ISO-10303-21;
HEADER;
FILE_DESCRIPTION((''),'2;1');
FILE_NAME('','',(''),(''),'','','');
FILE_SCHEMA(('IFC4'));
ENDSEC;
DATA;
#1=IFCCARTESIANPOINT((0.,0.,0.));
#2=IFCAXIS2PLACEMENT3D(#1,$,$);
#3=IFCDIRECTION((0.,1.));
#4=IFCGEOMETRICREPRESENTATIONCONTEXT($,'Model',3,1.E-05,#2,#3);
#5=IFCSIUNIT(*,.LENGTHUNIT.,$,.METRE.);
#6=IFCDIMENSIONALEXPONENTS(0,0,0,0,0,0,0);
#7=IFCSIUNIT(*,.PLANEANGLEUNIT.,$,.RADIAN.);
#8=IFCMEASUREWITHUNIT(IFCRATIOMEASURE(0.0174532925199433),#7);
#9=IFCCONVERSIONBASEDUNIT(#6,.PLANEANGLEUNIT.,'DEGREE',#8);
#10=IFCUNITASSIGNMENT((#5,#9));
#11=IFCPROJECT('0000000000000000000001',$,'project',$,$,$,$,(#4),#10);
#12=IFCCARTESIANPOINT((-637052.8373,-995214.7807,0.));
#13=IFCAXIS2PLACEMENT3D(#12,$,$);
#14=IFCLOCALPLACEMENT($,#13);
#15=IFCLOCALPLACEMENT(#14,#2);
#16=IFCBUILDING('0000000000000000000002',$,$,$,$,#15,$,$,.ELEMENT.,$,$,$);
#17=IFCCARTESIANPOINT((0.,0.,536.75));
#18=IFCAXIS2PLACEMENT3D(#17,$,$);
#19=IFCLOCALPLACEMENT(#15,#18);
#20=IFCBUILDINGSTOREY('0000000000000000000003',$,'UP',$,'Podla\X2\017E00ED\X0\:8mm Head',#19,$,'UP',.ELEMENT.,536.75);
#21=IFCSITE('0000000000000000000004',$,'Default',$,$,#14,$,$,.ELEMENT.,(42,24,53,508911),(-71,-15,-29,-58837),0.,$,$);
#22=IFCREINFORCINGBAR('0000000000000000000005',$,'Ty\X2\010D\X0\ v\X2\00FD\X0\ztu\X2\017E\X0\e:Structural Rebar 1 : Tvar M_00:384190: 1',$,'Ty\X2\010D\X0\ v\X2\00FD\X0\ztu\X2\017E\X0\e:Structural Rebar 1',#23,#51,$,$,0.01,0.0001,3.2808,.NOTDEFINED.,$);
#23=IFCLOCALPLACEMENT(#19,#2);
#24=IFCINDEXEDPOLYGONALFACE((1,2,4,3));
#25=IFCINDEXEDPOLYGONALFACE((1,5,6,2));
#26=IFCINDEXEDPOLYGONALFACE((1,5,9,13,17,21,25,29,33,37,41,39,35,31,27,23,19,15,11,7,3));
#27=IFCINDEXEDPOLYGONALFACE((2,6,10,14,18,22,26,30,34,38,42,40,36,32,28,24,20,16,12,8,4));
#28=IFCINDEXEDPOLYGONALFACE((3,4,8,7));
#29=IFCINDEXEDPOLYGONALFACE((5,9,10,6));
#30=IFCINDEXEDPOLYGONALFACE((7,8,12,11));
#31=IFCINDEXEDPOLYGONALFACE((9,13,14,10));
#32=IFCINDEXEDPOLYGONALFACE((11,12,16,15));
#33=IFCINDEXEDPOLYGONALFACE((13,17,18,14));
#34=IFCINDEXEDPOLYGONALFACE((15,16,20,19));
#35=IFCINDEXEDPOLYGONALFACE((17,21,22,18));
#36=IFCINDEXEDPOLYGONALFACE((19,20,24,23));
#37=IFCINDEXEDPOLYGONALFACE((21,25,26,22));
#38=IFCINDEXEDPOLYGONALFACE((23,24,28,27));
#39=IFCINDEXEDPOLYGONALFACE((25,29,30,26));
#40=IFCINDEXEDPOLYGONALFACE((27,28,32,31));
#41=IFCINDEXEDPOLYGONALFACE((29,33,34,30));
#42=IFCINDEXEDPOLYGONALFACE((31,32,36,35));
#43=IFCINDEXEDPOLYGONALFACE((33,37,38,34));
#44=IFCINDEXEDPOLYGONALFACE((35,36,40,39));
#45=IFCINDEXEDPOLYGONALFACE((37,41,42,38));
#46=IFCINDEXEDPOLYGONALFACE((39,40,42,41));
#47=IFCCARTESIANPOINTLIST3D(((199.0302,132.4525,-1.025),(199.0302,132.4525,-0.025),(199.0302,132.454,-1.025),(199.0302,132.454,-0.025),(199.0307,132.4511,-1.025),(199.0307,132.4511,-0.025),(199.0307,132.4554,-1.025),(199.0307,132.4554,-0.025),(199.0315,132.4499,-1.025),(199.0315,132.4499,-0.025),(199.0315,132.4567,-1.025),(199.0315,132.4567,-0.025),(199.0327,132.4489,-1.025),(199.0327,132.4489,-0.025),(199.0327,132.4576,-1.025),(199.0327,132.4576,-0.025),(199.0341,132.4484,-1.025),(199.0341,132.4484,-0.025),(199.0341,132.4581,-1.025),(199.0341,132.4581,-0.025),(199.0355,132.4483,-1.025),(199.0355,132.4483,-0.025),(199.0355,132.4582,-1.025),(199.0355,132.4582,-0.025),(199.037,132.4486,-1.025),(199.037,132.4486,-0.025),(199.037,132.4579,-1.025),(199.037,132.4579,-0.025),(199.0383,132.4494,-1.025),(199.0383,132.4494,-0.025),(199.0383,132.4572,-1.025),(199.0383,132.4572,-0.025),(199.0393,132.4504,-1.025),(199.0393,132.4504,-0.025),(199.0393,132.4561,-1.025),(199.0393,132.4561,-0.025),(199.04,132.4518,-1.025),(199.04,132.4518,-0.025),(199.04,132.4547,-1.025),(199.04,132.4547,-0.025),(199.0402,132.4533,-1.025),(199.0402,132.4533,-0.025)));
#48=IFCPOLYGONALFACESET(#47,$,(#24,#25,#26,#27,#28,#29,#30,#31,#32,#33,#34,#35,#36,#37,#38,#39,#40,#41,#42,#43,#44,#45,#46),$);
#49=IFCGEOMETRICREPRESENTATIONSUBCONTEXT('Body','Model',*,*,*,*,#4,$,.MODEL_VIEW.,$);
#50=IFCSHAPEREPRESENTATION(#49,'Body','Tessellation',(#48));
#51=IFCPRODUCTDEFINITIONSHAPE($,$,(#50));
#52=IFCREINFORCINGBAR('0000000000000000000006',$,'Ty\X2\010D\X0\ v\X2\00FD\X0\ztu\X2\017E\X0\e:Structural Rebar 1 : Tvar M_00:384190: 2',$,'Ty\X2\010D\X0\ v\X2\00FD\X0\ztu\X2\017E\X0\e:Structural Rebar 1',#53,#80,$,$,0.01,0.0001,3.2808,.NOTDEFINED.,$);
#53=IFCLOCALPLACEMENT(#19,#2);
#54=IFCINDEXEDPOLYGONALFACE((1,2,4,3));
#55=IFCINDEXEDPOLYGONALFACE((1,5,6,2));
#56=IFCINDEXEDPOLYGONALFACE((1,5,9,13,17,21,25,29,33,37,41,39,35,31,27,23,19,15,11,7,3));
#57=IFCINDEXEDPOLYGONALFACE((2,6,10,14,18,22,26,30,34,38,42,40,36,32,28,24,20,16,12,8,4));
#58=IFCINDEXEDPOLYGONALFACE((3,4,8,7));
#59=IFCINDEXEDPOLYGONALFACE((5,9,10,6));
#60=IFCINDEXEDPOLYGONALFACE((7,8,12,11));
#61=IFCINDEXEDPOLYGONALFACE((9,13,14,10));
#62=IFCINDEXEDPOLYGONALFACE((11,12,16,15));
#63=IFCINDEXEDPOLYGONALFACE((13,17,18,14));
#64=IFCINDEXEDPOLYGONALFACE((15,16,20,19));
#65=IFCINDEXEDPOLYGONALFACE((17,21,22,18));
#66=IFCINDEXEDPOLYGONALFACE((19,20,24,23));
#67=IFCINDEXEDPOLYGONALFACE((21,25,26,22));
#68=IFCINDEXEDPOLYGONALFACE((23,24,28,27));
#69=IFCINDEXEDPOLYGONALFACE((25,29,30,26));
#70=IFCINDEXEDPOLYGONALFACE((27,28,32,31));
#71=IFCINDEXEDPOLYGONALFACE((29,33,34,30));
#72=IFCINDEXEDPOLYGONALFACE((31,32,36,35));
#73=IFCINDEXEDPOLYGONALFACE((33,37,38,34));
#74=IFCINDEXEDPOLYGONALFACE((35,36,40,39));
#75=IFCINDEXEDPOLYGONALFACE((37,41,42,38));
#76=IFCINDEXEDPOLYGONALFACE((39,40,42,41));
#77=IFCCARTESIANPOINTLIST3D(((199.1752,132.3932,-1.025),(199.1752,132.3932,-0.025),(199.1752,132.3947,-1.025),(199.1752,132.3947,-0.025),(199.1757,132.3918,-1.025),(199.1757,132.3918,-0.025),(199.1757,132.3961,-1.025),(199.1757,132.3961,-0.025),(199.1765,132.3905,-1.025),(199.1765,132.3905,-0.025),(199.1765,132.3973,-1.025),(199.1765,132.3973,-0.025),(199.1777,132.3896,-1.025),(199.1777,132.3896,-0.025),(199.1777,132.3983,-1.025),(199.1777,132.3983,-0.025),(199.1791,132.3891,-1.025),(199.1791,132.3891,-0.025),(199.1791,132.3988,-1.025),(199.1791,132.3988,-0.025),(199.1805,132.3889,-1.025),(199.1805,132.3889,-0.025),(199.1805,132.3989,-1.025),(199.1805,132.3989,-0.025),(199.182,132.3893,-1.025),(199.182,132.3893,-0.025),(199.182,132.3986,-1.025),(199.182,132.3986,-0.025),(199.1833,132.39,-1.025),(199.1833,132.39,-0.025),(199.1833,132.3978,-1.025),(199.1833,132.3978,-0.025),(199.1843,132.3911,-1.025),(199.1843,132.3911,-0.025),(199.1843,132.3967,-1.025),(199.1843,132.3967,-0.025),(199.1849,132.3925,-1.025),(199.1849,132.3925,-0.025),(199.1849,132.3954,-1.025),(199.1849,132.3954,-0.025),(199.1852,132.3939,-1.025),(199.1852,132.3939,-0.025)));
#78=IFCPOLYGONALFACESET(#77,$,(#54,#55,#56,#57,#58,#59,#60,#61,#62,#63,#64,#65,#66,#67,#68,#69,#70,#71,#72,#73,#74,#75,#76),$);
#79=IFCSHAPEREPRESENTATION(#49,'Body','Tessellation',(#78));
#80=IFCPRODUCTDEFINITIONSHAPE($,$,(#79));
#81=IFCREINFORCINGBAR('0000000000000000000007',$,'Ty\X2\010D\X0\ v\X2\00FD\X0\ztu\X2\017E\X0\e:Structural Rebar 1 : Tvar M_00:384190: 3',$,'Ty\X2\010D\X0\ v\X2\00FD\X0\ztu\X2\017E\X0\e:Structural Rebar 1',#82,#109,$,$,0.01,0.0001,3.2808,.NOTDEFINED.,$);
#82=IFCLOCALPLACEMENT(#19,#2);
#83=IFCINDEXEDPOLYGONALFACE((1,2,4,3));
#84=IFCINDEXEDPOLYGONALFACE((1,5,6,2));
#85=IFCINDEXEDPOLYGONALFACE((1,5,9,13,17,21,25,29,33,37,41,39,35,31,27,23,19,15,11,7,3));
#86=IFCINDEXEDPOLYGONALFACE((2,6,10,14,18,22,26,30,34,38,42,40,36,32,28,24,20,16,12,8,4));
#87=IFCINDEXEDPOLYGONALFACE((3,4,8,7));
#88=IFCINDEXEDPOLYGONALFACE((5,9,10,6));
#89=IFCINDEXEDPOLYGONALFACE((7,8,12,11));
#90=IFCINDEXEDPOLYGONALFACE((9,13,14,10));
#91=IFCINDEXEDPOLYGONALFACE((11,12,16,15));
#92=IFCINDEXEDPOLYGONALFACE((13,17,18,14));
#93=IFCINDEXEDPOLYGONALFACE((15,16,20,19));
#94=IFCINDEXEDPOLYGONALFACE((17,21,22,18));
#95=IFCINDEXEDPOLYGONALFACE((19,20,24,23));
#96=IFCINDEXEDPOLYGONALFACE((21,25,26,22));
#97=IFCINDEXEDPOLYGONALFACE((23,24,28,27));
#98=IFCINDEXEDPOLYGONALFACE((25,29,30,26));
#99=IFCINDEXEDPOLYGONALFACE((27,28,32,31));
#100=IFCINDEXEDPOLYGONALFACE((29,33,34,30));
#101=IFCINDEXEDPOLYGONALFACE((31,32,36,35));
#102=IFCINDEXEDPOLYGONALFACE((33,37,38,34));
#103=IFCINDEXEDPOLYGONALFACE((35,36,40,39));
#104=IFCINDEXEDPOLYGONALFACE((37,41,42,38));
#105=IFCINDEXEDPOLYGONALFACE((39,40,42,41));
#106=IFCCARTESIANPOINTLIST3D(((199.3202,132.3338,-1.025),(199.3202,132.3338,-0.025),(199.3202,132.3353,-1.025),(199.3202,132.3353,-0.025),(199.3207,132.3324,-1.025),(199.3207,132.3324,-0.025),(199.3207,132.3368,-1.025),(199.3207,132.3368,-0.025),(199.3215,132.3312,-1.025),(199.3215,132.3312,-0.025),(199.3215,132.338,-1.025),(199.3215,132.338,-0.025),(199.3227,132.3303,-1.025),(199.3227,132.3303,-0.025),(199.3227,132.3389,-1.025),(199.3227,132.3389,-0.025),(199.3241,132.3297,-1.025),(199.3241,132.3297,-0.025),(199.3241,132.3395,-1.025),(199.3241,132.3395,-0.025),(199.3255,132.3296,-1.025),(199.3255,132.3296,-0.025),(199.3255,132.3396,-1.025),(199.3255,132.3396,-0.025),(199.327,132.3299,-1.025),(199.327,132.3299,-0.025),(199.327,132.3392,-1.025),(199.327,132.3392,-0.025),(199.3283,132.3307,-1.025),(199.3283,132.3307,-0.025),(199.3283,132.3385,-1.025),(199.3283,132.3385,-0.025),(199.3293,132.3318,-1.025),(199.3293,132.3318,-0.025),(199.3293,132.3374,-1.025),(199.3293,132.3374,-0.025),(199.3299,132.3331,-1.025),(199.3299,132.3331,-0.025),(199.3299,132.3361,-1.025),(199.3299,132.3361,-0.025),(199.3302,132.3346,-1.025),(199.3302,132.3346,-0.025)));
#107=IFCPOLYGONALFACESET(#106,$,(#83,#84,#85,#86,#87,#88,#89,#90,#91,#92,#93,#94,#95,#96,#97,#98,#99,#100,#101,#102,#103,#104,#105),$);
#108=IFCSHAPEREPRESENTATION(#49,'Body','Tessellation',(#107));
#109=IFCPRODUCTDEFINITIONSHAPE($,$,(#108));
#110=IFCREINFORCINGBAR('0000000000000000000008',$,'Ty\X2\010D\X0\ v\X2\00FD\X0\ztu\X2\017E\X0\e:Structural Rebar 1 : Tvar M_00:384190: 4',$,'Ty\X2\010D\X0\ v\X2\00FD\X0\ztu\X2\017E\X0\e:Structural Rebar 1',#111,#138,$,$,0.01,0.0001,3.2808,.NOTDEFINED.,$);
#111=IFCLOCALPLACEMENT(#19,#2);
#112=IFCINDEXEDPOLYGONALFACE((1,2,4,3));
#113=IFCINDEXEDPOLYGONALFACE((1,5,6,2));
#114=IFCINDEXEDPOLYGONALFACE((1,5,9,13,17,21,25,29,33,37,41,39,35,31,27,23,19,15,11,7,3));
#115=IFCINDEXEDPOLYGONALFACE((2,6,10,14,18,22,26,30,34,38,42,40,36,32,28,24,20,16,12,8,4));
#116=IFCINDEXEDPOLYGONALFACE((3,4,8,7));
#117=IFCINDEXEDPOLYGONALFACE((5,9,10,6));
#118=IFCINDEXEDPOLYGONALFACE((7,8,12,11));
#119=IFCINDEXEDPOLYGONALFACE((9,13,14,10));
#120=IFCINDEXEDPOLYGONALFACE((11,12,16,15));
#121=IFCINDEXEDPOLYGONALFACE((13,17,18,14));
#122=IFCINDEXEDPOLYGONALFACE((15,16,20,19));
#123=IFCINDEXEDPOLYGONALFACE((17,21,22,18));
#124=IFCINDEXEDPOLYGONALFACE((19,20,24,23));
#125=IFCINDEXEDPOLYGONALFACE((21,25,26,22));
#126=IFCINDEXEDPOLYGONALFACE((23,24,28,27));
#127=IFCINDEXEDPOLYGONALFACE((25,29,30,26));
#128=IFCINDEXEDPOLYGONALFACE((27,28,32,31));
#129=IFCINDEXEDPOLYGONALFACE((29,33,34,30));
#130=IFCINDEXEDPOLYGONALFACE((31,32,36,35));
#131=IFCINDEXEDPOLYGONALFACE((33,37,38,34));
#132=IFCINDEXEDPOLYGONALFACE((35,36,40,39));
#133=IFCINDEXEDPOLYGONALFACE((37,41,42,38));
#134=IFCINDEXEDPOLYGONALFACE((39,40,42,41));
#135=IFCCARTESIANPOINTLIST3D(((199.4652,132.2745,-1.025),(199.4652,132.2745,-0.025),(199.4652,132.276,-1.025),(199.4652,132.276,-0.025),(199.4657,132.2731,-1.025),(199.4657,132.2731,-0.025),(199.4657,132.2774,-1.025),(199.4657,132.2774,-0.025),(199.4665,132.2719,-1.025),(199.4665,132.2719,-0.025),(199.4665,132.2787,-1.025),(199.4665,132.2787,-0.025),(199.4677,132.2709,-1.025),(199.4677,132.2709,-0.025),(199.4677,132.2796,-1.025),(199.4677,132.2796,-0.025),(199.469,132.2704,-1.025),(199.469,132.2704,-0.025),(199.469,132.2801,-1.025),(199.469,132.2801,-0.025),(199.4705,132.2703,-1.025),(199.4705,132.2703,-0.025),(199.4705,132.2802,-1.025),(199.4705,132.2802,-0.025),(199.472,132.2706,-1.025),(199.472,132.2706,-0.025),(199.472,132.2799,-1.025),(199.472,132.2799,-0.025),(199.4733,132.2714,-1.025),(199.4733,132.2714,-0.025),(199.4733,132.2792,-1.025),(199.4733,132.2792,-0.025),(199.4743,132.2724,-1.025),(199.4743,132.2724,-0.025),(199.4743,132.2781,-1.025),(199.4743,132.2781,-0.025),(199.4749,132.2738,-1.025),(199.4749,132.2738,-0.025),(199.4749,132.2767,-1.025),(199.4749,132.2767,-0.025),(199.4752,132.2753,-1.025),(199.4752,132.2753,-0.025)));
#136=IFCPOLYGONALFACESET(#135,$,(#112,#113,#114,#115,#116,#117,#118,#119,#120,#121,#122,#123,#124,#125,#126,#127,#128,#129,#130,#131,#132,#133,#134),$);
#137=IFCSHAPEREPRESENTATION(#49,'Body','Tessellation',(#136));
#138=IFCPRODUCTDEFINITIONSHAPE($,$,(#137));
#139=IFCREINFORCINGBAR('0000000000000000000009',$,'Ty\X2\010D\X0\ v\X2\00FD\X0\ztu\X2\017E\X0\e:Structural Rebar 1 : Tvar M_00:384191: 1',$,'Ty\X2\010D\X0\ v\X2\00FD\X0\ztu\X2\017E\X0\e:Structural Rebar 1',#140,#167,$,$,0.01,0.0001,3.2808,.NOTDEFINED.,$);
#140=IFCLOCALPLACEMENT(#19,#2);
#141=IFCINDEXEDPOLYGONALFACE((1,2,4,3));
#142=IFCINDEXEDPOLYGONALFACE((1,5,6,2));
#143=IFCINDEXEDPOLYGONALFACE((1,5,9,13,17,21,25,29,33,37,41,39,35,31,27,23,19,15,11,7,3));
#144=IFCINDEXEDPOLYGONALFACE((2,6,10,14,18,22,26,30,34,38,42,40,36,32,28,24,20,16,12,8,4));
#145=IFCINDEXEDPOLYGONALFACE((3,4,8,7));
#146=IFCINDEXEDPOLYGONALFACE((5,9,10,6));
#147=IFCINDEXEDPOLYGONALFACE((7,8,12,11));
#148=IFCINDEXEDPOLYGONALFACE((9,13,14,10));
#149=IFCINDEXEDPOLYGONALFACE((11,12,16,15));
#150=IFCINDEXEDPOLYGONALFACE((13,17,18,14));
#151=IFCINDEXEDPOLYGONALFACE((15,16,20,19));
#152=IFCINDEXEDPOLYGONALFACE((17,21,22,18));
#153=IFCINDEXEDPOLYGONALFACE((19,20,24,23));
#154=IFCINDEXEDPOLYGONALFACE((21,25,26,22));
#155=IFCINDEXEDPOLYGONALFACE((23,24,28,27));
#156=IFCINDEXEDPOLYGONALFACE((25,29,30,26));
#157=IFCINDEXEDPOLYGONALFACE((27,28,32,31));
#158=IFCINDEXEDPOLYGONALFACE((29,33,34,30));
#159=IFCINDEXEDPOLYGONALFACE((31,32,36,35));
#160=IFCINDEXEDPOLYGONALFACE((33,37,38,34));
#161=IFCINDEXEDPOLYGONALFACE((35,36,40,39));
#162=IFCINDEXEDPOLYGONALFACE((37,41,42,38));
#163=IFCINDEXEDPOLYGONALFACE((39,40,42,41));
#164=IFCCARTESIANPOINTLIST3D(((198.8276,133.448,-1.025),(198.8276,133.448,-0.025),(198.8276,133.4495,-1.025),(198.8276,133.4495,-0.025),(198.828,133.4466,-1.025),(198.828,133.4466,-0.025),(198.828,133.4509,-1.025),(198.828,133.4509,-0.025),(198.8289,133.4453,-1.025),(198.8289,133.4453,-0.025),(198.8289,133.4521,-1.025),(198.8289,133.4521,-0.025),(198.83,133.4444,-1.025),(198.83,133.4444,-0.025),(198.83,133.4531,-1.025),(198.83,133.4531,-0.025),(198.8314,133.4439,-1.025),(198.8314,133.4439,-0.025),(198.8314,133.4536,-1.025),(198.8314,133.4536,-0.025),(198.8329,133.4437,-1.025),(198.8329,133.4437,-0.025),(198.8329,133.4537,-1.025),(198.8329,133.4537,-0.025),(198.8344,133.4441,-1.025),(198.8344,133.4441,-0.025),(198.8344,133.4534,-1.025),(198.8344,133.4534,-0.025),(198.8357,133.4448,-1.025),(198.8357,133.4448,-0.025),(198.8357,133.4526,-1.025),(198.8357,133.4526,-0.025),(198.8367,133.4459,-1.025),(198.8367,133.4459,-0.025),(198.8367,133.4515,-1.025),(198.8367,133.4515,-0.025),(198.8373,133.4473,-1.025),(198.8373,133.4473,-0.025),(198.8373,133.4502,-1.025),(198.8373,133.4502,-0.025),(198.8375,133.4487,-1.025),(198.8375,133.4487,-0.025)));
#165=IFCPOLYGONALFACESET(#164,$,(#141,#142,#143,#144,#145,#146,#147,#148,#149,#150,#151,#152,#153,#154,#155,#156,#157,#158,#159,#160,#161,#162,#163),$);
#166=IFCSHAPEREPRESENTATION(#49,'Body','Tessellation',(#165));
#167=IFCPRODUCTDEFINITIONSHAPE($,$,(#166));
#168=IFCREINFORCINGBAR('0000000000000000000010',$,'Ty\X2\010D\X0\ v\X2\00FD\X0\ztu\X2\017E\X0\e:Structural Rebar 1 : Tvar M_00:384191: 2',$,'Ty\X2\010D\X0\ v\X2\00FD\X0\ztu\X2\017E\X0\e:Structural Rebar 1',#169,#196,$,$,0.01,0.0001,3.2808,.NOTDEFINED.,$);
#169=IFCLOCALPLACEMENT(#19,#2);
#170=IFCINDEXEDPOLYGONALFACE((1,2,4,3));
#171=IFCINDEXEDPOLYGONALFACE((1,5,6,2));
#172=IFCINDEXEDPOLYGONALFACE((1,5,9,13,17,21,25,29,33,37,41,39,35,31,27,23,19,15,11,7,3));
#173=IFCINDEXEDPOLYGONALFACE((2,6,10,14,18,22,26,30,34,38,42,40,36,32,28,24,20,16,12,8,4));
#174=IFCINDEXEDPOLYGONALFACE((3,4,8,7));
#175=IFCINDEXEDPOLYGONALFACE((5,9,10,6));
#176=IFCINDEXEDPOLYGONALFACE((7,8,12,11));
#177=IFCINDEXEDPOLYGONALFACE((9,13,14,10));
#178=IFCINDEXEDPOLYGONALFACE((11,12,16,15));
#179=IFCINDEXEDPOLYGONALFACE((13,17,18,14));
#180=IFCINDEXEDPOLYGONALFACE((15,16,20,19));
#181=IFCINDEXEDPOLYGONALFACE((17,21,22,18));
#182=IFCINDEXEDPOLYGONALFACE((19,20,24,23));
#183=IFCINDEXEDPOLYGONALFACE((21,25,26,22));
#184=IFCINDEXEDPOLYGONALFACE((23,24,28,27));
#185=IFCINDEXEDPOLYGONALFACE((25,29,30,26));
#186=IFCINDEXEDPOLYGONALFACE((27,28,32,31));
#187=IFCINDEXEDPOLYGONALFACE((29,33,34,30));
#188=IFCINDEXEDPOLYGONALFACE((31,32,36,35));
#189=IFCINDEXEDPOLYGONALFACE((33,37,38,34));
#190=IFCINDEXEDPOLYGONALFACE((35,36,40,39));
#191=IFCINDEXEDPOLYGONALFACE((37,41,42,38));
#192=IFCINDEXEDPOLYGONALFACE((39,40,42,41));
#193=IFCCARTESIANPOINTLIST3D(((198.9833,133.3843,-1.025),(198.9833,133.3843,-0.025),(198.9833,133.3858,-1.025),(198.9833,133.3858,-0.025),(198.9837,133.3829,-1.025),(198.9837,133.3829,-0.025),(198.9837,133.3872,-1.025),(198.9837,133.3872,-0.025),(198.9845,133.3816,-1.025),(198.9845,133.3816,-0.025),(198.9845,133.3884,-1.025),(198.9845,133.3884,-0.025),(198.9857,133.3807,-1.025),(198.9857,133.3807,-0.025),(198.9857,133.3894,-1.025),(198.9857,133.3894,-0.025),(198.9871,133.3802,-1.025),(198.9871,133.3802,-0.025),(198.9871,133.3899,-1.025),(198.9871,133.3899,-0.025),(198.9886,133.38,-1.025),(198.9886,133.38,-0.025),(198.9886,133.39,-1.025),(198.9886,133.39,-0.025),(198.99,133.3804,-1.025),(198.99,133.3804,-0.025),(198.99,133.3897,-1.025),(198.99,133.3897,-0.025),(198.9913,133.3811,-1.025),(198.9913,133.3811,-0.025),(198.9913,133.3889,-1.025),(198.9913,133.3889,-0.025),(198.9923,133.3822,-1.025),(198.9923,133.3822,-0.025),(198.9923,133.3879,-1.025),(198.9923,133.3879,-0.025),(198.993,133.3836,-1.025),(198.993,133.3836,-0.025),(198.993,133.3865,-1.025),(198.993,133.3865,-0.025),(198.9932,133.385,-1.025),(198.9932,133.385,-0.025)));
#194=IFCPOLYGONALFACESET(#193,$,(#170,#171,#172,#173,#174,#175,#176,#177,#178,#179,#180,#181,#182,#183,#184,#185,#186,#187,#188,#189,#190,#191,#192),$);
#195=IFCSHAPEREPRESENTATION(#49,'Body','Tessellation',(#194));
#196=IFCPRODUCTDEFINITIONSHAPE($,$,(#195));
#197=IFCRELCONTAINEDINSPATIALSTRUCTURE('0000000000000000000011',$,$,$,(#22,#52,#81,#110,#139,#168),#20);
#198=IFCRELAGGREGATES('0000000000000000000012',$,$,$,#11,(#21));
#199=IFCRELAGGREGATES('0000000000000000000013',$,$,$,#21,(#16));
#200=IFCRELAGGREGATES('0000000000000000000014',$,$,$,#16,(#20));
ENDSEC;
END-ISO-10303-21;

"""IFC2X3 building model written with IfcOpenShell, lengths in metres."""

from ifc_helpers import new_model, entity, si_unit, converted_unit, direction, frame, origin, place, context, subcontext, project, spatial, element, save


model = new_model("IFC2X3")

# Units and contexts
model_context = context("Model", 3, precision=1e-05, world=origin(), true_north=direction((0.0, 1.0)))
body_context = subcontext(model_context, "Body", "Model", "MODEL_VIEW")
ifc_project = project(units=[si_unit("LENGTHUNIT", "METRE"), converted_unit("PLANEANGLEUNIT", "DEGREE", entity("IfcRatioMeasure", 0.0174532925199433), si_unit("PLANEANGLEUNIT", "RADIAN"), dimensions=[0, 0, 0, 0, 0, 0, 0])], contexts=[model_context])

# Site, building, storey
site_placement = place(None, frame((-637052.8373, -995214.7807, 0.0)))
site = spatial("IfcSite", under=ifc_project, at=site_placement, Name="Default", CompositionType="ELEMENT", RefLatitude=(42, 24, 53, 508911), RefLongitude=(-71, -15, -29, -58837), RefElevation=0.0)
building_placement = place(site_placement, origin())
building = spatial("IfcBuilding", under=site, at=building_placement, CompositionType="ELEMENT")
storey_placement = place(building_placement, frame((0.0, 0.0, 536.75)))
storey = spatial("IfcBuildingStorey", under=building, at=storey_placement, Name="UP", ObjectType="Podlaží:8mm Head", LongName="UP", CompositionType="ELEMENT", Elevation=536.75)

# Reinforcing bars
reinforcing_bar_1_placement = place(storey_placement, origin())
element("IfcReinforcingBar", 1, at=reinforcing_bar_1_placement, inside=storey, Name="Tyč výztuže:Structural Rebar 1 : Tvar M_00:384190: 1", ObjectType="Tyč výztuže:Structural Rebar 1", BarLength=3.2808, BarRole="NOTDEFINED", CrossSectionArea=0.0001, NominalDiameter=0.01, context=body_context, shape_type="AdvancedSweptSolid", body=[
    entity("IfcSweptDiskSolid", entity("IfcCompositeCurve", [entity("IfcCompositeCurveSegment", "CONTINUOUS", True, entity("IfcPolyline", [entity("IfcCartesianPoint", [-199.0352, -132.4533, 0.025]), entity("IfcCartesianPoint", [-199.0352, -132.4533, 1.025])]))], False), 0.005, None, 0.0, 1.0),
])
reinforcing_bar_2_placement = place(storey_placement, origin())
element("IfcReinforcingBar", 2, at=reinforcing_bar_2_placement, inside=storey, Name="Tyč výztuže:Structural Rebar 1 : Tvar M_00:384190: 2", ObjectType="Tyč výztuže:Structural Rebar 1", BarLength=3.2808, BarRole="NOTDEFINED", CrossSectionArea=0.0001, NominalDiameter=0.01, context=body_context, shape_type="AdvancedSweptSolid", body=[
    entity("IfcSweptDiskSolid", entity("IfcCompositeCurve", [entity("IfcCompositeCurveSegment", "CONTINUOUS", True, entity("IfcPolyline", [entity("IfcCartesianPoint", [-199.1802, -132.3939, 0.025]), entity("IfcCartesianPoint", [-199.1802, -132.3939, 1.025])]))], False), 0.005, None, 0.0, 1.0),
])
reinforcing_bar_3_placement = place(storey_placement, origin())
element("IfcReinforcingBar", 3, at=reinforcing_bar_3_placement, inside=storey, Name="Tyč výztuže:Structural Rebar 1 : Tvar M_00:384190: 3", ObjectType="Tyč výztuže:Structural Rebar 1", BarLength=3.2808, BarRole="NOTDEFINED", CrossSectionArea=0.0001, NominalDiameter=0.01, context=body_context, shape_type="AdvancedSweptSolid", body=[
    entity("IfcSweptDiskSolid", entity("IfcCompositeCurve", [entity("IfcCompositeCurveSegment", "CONTINUOUS", True, entity("IfcPolyline", [entity("IfcCartesianPoint", [-199.3252, -132.3346, 0.025]), entity("IfcCartesianPoint", [-199.3252, -132.3346, 1.025])]))], False), 0.005, None, 0.0, 1.0),
])
reinforcing_bar_4_placement = place(storey_placement, origin())
element("IfcReinforcingBar", 4, at=reinforcing_bar_4_placement, inside=storey, Name="Tyč výztuže:Structural Rebar 1 : Tvar M_00:384190: 4", ObjectType="Tyč výztuže:Structural Rebar 1", BarLength=3.2808, BarRole="NOTDEFINED", CrossSectionArea=0.0001, NominalDiameter=0.01, context=body_context, shape_type="AdvancedSweptSolid", body=[
    entity("IfcSweptDiskSolid", entity("IfcCompositeCurve", [entity("IfcCompositeCurveSegment", "CONTINUOUS", True, entity("IfcPolyline", [entity("IfcCartesianPoint", [-199.4702, -132.2753, 0.025]), entity("IfcCartesianPoint", [-199.4702, -132.2753, 1.025])]))], False), 0.005, None, 0.0, 1.0),
])
reinforcing_bar_5_placement = place(storey_placement, origin())
element("IfcReinforcingBar", 5, at=reinforcing_bar_5_placement, inside=storey, Name="Tyč výztuže:Structural Rebar 1 : Tvar M_00:384191: 1", ObjectType="Tyč výztuže:Structural Rebar 1", BarLength=3.2808, BarRole="NOTDEFINED", CrossSectionArea=0.0001, NominalDiameter=0.01, context=body_context, shape_type="AdvancedSweptSolid", body=[
    entity("IfcSweptDiskSolid", entity("IfcCompositeCurve", [entity("IfcCompositeCurveSegment", "CONTINUOUS", True, entity("IfcPolyline", [entity("IfcCartesianPoint", [-198.8325, -133.4487, 0.025]), entity("IfcCartesianPoint", [-198.8325, -133.4487, 1.025])]))], False), 0.005, None, 0.0, 1.0),
])
reinforcing_bar_6_placement = place(storey_placement, origin())
element("IfcReinforcingBar", 6, at=reinforcing_bar_6_placement, inside=storey, Name="Tyč výztuže:Structural Rebar 1 : Tvar M_00:384191: 2", ObjectType="Tyč výztuže:Structural Rebar 1", BarLength=3.2808, BarRole="NOTDEFINED", CrossSectionArea=0.0001, NominalDiameter=0.01, context=body_context, shape_type="AdvancedSweptSolid", body=[
    entity("IfcSweptDiskSolid", entity("IfcCompositeCurve", [entity("IfcCompositeCurveSegment", "CONTINUOUS", True, entity("IfcPolyline", [entity("IfcCartesianPoint", [-198.9882, -133.385, 0.025]), entity("IfcCartesianPoint", [-198.9882, -133.385, 1.025])]))], False), 0.005, None, 0.0, 1.0),
])

save(model, "model.ifc")
